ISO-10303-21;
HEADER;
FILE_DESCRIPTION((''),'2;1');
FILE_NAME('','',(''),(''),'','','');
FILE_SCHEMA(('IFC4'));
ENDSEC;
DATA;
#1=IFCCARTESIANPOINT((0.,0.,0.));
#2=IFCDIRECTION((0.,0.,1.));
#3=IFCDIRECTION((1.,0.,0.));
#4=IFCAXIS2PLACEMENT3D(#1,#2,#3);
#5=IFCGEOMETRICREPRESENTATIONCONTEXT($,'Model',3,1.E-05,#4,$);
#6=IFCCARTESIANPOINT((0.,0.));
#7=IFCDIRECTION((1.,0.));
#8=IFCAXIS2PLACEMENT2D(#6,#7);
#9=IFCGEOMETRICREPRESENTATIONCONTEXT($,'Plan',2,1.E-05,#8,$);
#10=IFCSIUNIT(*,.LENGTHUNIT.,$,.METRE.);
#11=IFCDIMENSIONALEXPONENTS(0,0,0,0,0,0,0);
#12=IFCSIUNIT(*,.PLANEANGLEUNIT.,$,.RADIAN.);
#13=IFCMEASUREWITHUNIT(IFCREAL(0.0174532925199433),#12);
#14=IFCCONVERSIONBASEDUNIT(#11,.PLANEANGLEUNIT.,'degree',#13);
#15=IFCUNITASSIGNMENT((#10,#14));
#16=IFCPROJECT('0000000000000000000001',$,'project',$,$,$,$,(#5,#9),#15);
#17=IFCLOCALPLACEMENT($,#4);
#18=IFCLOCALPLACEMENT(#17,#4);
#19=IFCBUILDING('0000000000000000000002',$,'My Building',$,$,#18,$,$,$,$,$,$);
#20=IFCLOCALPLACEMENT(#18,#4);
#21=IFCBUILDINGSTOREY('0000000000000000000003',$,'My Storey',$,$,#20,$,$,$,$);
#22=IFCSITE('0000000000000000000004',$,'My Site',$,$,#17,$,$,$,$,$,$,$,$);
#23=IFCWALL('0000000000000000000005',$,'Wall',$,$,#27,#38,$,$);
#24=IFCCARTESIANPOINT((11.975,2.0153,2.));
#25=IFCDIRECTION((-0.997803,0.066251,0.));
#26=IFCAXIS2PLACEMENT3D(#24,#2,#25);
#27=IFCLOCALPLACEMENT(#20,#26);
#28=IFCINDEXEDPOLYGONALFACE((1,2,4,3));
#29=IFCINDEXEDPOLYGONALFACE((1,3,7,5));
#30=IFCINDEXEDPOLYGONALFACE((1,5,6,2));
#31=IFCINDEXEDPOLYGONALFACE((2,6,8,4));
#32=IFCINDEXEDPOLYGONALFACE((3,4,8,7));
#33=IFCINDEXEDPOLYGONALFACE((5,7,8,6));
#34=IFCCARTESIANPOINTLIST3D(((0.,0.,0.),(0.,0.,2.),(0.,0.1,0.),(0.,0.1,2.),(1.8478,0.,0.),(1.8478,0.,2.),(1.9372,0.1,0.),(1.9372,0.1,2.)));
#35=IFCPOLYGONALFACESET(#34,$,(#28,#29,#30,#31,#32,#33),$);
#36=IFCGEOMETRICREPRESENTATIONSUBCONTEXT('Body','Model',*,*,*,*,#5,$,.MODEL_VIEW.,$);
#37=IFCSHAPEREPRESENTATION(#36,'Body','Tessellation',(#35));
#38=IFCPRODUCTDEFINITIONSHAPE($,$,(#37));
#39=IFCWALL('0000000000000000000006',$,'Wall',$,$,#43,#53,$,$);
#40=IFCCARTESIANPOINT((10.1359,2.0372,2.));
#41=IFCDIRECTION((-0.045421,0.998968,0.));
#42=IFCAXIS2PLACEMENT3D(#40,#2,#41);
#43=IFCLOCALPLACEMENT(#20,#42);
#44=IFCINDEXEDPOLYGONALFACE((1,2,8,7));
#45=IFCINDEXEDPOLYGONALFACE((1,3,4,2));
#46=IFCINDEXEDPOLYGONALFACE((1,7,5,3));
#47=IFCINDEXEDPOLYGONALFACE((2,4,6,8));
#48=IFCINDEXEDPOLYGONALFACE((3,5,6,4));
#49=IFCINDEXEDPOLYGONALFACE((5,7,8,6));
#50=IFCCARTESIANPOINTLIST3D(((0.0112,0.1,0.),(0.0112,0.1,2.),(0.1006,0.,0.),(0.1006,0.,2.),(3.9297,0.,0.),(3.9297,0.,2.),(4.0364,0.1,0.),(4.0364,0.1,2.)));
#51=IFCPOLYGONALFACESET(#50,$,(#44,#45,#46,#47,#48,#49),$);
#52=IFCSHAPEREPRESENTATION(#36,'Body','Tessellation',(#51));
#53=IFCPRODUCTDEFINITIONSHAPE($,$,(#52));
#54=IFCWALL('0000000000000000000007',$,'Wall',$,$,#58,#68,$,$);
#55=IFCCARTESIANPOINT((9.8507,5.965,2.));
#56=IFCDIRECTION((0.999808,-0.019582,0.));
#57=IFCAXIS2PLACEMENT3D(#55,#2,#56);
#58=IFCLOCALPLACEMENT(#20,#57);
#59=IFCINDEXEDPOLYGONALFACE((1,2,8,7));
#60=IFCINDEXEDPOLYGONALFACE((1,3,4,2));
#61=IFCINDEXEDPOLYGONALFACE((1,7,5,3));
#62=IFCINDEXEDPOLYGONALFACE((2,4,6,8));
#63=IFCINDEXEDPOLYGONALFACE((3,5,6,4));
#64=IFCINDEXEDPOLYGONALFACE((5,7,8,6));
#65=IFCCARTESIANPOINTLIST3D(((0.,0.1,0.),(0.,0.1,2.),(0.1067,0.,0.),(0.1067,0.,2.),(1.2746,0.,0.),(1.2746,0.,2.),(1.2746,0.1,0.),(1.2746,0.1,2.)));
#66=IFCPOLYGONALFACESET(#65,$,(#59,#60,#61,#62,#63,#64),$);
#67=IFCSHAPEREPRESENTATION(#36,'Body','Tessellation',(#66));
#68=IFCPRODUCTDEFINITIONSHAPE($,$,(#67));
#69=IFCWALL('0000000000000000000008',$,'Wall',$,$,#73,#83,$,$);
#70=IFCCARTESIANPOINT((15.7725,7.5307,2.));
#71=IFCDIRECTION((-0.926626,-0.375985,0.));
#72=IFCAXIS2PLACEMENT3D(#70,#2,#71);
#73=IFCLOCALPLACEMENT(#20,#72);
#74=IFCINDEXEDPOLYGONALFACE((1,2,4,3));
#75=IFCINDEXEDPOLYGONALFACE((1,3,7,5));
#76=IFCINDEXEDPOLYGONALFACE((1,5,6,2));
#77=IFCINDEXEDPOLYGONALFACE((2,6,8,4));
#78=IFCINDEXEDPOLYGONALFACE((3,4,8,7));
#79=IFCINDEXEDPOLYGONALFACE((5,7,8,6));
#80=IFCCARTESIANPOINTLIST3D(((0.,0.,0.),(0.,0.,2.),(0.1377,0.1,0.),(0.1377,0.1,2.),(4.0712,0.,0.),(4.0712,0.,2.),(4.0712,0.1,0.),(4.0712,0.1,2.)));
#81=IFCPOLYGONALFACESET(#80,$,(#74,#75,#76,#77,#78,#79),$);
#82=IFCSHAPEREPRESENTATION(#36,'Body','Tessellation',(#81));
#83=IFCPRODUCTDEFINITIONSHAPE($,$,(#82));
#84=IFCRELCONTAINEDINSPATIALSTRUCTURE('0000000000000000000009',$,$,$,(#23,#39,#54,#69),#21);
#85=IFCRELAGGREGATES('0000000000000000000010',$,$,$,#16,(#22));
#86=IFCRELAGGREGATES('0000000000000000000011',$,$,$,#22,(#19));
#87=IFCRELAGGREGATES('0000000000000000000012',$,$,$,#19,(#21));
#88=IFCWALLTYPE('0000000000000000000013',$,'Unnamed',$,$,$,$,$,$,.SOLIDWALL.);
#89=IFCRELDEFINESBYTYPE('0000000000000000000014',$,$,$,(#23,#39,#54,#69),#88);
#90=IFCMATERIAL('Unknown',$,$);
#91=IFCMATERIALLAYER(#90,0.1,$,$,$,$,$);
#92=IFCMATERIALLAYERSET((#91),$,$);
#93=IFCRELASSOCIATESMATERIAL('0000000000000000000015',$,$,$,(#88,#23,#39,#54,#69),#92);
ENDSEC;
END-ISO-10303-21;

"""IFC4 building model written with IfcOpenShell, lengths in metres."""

from ifc_helpers import new_model, entity, si_unit, converted_unit, frame, origin_with_axes, origin_2d_with_axis, place, context, subcontext, project, spatial, indexed_curve, outline, extrude, clip, halfspace, material, layer, layer_set, layer_usage, type_object, element, save


model = new_model("IFC4")

# Units and contexts
model_context = context("Model", 3, precision=1e-05, world=origin_with_axes())
plan_context = context("Plan", 2, precision=1e-05, world=origin_2d_with_axis())
body_context_1 = subcontext(model_context, "Body", "Model", "MODEL_VIEW")
ifc_project = project(units=[si_unit("LENGTHUNIT", "METRE"), converted_unit("PLANEANGLEUNIT", "degree", entity("IfcReal", 0.0174532925199433), si_unit("PLANEANGLEUNIT", "RADIAN"), dimensions=[0, 0, 0, 0, 0, 0, 0])], contexts=[model_context, plan_context])

# Site, building, storey
site_placement = place(None, origin_with_axes())
site = spatial("IfcSite", under=ifc_project, at=site_placement, Name="My Site")
building_placement = place(site_placement, origin_with_axes())
building = spatial("IfcBuilding", under=site, at=building_placement, Name="My Building")
storey_placement = place(building_placement, origin_with_axes())
storey = spatial("IfcBuildingStorey", under=building, at=storey_placement, Name="My Storey")

# Shared definitions
ifc_material = material(Name="Unknown")

# Walls
ifc_layer_1 = layer(ifc_material, 0.1)
ifc_layer_set_1 = layer_set([ifc_layer_1])
wall_type = type_object("IfcWallType", Name="Unnamed", PredefinedType="SOLIDWALL", material=ifc_layer_set_1)
ifc_layer_usage_1 = layer_usage(ifc_layer_set_1, "AXIS2", "POSITIVE", 0.0)
wall_1_placement = place(storey_placement, frame((11.975, 2.0153, 2.0), z_axis=(0.0, 0.0, 1.0), x_axis=(-0.997803, 0.066251, 0.0)))
element("IfcWall", 1, at=wall_1_placement, inside=storey, type_object=wall_type, material=ifc_layer_usage_1, Name="Wall", context=body_context_1, shape_type="Clipping", body=[
    clip(extrude(outline(indexed_curve([(0.0, 0.0), (0.0, 0.1), (1.9484, 0.1), (1.9484, 0.0), (0.0, 0.0)], self_intersect=False)), origin_with_axes(), (0.0, 0.0, 1.0), 2.0), halfspace(frame((1.8478, 0.0, -2.0), z_axis=(0.745485, -0.666522, 0.0), x_axis=(-0.666522, -0.745485, 0.0)), False)),
])
ifc_layer_usage_2 = layer_usage(ifc_layer_set_1, "AXIS2", "POSITIVE", 0.0)
wall_2_placement = place(storey_placement, frame((10.1359, 2.0372, 2.0), z_axis=(0.0, 0.0, 1.0), x_axis=(-0.045421, 0.998968, 0.0)))
element("IfcWall", 2, at=wall_2_placement, inside=storey, type_object=wall_type, material=ifc_layer_usage_2, Name="Wall", context=body_context_1, shape_type="Clipping", body=[
    clip(clip(extrude(outline(indexed_curve([(0.0, 0.0), (0.0, 0.1), (4.0364, 0.1), (4.0364, 0.0), (0.0, 0.0)], self_intersect=False)), origin_with_axes(), (0.0, 0.0, 1.0), 2.0), halfspace(frame((3.9297, 0.0, -2.0), z_axis=(0.683758, -0.729709, 0.0), x_axis=(-0.729709, -0.683758, 0.0)), False)), halfspace(frame((0.1006, 0.0, -2.0), z_axis=(-0.745494, -0.666512, 0.0), x_axis=(-0.666512, 0.745494, 0.0)), False)),
])
ifc_layer_usage_3 = layer_usage(ifc_layer_set_1, "AXIS2", "POSITIVE", 0.0)
wall_3_placement = place(storey_placement, frame((9.8507, 5.965, 2.0), z_axis=(0.0, 0.0, 1.0), x_axis=(0.999808, -0.019582, 0.0)))
element("IfcWall", 3, at=wall_3_placement, inside=storey, type_object=wall_type, material=ifc_layer_usage_3, Name="Wall", context=body_context_1, shape_type="Clipping", body=[
    clip(extrude(outline(indexed_curve([(0.0, 0.0), (0.0, 0.1), (1.2746, 0.1), (1.2746, 0.0), (0.0, 0.0)], self_intersect=False)), origin_with_axes(), (0.0, 0.0, 1.0), 2.0), halfspace(frame((0.1067, 0.0, -2.0), z_axis=(-0.683744, -0.729722, 0.0), x_axis=(-0.729722, 0.683744, 0.0)), False)),
])
ifc_layer_usage_4 = layer_usage(ifc_layer_set_1, "AXIS2", "POSITIVE", 0.0)
wall_4_placement = place(storey_placement, frame((15.7725, 7.5307, 2.0), z_axis=(0.0, 0.0, 1.0), x_axis=(-0.926626, -0.375985, 0.0)))
element("IfcWall", 4, at=wall_4_placement, inside=storey, type_object=wall_type, material=ifc_layer_usage_4, Name="Wall", context=body_context_1, shape_type="Clipping", body=[
    clip(extrude(outline(indexed_curve([(0.0, 0.0), (0.0, 0.1), (4.0712, 0.1), (4.0712, 0.0), (0.0, 0.0)], self_intersect=False)), origin_with_axes(), (0.0, 0.0, 1.0), 2.0), halfspace(frame((0.0, 0.0, -2.0), z_axis=(-0.587596, 0.809155, 0.0), x_axis=(0.809155, 0.587596, 0.0)), False)),
])

save(model, "model.ifc")
